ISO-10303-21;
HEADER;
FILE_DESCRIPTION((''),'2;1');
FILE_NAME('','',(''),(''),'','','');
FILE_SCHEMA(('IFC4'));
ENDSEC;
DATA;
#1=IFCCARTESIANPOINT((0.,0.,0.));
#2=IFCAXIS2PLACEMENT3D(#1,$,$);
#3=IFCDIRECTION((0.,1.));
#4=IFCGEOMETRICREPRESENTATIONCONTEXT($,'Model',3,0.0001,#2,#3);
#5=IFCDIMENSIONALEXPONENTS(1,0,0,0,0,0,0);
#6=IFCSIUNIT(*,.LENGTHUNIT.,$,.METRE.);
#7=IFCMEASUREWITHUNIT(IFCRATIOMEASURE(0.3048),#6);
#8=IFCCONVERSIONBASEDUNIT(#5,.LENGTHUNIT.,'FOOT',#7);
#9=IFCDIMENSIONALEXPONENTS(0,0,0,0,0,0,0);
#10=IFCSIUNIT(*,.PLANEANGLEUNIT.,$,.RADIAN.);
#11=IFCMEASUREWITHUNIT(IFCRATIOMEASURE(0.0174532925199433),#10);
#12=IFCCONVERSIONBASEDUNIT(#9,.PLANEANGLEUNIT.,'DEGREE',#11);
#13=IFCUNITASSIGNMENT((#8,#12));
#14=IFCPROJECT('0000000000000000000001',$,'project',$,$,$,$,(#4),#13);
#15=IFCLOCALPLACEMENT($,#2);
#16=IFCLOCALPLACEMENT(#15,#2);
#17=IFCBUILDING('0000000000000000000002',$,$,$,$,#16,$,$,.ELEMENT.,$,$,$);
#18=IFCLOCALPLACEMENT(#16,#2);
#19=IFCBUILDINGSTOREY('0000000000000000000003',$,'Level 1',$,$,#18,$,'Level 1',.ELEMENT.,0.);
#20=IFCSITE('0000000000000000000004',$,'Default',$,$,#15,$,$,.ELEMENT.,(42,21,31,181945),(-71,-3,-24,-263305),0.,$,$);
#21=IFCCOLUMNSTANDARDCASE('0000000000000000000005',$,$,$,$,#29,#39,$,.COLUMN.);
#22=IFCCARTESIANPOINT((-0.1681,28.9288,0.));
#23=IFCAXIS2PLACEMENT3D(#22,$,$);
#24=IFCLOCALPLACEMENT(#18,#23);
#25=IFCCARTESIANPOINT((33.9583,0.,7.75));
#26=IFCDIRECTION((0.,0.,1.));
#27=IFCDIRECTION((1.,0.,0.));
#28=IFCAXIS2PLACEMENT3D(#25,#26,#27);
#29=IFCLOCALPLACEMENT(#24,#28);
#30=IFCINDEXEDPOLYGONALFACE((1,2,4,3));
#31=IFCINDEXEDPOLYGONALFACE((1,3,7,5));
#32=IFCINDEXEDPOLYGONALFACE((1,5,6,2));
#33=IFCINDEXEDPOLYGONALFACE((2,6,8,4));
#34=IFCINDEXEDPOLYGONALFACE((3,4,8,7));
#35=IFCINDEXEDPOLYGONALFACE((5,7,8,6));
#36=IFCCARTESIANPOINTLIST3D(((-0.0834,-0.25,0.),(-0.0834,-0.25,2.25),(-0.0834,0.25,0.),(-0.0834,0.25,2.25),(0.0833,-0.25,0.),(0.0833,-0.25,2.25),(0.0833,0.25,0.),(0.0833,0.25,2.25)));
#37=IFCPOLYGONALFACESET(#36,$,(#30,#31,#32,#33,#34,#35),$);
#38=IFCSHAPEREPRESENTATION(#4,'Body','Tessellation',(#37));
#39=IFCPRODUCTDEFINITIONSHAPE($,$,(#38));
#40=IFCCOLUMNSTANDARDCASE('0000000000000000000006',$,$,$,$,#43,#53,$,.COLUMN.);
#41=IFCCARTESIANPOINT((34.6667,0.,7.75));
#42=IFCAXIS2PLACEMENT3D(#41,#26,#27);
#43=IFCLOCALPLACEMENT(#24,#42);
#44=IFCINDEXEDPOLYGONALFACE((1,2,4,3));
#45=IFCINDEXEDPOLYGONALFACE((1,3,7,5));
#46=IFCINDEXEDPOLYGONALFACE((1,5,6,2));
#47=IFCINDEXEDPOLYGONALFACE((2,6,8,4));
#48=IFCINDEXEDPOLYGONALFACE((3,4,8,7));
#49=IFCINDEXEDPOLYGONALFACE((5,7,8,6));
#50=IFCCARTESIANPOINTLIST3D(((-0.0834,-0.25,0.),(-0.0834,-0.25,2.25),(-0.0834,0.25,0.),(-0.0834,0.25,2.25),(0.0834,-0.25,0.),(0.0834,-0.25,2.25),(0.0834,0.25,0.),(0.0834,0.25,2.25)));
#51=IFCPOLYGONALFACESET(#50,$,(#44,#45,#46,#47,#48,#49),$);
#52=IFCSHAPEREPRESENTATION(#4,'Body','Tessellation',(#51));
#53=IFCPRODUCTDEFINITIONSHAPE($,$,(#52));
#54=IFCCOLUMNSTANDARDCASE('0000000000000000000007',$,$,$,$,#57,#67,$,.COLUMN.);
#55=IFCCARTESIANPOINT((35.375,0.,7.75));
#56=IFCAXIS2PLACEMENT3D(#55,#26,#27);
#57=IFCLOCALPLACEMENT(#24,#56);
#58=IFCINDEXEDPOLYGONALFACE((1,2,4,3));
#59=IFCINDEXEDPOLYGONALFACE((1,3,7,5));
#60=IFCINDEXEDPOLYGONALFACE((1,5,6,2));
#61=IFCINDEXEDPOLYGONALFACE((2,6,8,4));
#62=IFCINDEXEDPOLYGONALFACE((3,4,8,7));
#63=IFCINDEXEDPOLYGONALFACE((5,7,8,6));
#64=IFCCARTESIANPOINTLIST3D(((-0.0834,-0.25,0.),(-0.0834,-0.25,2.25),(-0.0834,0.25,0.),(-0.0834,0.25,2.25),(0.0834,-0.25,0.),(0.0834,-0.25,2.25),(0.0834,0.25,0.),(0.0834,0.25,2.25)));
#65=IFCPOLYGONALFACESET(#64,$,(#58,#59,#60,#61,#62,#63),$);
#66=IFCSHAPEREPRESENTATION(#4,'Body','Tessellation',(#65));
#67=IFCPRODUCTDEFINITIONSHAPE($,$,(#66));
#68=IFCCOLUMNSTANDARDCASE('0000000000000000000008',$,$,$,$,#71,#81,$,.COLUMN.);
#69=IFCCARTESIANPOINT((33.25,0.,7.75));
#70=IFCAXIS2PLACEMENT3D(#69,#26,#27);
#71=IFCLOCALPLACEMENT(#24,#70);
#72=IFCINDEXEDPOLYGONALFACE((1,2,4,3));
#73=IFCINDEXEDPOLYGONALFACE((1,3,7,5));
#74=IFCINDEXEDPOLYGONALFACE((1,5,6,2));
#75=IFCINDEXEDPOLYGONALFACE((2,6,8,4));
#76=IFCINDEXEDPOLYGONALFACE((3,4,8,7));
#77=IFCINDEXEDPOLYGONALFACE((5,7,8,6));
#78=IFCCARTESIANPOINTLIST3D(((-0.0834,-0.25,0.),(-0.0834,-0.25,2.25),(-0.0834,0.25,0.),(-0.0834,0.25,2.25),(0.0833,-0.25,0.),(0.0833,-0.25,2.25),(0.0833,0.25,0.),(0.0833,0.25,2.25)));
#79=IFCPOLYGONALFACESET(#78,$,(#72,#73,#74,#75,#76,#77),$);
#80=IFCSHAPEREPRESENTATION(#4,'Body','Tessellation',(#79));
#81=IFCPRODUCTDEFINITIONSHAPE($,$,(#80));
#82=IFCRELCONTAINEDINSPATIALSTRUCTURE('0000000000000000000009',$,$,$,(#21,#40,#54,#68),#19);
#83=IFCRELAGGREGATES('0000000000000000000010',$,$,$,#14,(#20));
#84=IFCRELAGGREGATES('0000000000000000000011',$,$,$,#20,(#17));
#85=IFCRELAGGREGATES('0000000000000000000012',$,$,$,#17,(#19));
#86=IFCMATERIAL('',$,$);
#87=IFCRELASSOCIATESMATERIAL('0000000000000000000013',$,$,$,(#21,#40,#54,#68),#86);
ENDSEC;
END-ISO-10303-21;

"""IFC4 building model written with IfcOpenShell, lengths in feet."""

from ifc_helpers import new_model, entity, si_unit, converted_unit, direction, frame, origin, place, context, project, spatial, rectangle, extrude, material, element, save


model = new_model("IFC4")

# Units and contexts
model_context = context("Model", 3, precision=0.0001, world=origin(), true_north=direction((0.0, 1.0)))
ifc_project = project(units=[converted_unit("LENGTHUNIT", "FOOT", entity("IfcRatioMeasure", 0.3048), si_unit("LENGTHUNIT", "METRE"), dimensions=[1, 0, 0, 0, 0, 0, 0]), converted_unit("PLANEANGLEUNIT", "DEGREE", entity("IfcRatioMeasure", 0.0174532925199433), si_unit("PLANEANGLEUNIT", "RADIAN"), dimensions=[0, 0, 0, 0, 0, 0, 0])], contexts=[model_context])

# Site, building, storey
site_placement = place(None, origin())
site = spatial("IfcSite", under=ifc_project, at=site_placement, Name="Default", CompositionType="ELEMENT", RefLatitude=(42, 21, 31, 181945), RefLongitude=(-71, -3, -24, -263305), RefElevation=0.0)
building_placement = place(site_placement, origin())
building = spatial("IfcBuilding", under=site, at=building_placement, CompositionType="ELEMENT")
storey_placement = place(building_placement, origin())
storey = spatial("IfcBuildingStorey", under=building, at=storey_placement, Name="Level 1", LongName="Level 1", CompositionType="ELEMENT", Elevation=0.0)

# Columns
ifc_material_1 = material(Name="")
placement = place(storey_placement, frame((-0.1681, 28.9288, 0.0)))
for number, where, z_axis, x_axis in (
    (1, (33.9583, 0.0, 7.75), (0.0, 0.0, 1.0), (1.0, 0.0, 0.0)),
    (2, (34.6667, 0.0, 7.75), (0.0, 0.0, 1.0), (1.0, 0.0, 0.0)),
    (3, (35.375, 0.0, 7.75), (0.0, 0.0, 1.0), (1.0, 0.0, 0.0)),
    (4, (33.25, 0.0, 7.75), (0.0, 0.0, 1.0), (1.0, 0.0, 0.0)),
):
    element("IfcColumnStandardCase", number, at=place(placement, frame(where, z_axis=z_axis, x_axis=x_axis)), inside=storey, material=ifc_material_1, PredefinedType="COLUMN", context=model_context, shape_type="SweptSolid", body=[
        extrude(rectangle(XDim=0.1667, YDim=0.5), origin(), (0.0, 0.0, 1.0), 2.25),
    ])

save(model, "model.ifc")
